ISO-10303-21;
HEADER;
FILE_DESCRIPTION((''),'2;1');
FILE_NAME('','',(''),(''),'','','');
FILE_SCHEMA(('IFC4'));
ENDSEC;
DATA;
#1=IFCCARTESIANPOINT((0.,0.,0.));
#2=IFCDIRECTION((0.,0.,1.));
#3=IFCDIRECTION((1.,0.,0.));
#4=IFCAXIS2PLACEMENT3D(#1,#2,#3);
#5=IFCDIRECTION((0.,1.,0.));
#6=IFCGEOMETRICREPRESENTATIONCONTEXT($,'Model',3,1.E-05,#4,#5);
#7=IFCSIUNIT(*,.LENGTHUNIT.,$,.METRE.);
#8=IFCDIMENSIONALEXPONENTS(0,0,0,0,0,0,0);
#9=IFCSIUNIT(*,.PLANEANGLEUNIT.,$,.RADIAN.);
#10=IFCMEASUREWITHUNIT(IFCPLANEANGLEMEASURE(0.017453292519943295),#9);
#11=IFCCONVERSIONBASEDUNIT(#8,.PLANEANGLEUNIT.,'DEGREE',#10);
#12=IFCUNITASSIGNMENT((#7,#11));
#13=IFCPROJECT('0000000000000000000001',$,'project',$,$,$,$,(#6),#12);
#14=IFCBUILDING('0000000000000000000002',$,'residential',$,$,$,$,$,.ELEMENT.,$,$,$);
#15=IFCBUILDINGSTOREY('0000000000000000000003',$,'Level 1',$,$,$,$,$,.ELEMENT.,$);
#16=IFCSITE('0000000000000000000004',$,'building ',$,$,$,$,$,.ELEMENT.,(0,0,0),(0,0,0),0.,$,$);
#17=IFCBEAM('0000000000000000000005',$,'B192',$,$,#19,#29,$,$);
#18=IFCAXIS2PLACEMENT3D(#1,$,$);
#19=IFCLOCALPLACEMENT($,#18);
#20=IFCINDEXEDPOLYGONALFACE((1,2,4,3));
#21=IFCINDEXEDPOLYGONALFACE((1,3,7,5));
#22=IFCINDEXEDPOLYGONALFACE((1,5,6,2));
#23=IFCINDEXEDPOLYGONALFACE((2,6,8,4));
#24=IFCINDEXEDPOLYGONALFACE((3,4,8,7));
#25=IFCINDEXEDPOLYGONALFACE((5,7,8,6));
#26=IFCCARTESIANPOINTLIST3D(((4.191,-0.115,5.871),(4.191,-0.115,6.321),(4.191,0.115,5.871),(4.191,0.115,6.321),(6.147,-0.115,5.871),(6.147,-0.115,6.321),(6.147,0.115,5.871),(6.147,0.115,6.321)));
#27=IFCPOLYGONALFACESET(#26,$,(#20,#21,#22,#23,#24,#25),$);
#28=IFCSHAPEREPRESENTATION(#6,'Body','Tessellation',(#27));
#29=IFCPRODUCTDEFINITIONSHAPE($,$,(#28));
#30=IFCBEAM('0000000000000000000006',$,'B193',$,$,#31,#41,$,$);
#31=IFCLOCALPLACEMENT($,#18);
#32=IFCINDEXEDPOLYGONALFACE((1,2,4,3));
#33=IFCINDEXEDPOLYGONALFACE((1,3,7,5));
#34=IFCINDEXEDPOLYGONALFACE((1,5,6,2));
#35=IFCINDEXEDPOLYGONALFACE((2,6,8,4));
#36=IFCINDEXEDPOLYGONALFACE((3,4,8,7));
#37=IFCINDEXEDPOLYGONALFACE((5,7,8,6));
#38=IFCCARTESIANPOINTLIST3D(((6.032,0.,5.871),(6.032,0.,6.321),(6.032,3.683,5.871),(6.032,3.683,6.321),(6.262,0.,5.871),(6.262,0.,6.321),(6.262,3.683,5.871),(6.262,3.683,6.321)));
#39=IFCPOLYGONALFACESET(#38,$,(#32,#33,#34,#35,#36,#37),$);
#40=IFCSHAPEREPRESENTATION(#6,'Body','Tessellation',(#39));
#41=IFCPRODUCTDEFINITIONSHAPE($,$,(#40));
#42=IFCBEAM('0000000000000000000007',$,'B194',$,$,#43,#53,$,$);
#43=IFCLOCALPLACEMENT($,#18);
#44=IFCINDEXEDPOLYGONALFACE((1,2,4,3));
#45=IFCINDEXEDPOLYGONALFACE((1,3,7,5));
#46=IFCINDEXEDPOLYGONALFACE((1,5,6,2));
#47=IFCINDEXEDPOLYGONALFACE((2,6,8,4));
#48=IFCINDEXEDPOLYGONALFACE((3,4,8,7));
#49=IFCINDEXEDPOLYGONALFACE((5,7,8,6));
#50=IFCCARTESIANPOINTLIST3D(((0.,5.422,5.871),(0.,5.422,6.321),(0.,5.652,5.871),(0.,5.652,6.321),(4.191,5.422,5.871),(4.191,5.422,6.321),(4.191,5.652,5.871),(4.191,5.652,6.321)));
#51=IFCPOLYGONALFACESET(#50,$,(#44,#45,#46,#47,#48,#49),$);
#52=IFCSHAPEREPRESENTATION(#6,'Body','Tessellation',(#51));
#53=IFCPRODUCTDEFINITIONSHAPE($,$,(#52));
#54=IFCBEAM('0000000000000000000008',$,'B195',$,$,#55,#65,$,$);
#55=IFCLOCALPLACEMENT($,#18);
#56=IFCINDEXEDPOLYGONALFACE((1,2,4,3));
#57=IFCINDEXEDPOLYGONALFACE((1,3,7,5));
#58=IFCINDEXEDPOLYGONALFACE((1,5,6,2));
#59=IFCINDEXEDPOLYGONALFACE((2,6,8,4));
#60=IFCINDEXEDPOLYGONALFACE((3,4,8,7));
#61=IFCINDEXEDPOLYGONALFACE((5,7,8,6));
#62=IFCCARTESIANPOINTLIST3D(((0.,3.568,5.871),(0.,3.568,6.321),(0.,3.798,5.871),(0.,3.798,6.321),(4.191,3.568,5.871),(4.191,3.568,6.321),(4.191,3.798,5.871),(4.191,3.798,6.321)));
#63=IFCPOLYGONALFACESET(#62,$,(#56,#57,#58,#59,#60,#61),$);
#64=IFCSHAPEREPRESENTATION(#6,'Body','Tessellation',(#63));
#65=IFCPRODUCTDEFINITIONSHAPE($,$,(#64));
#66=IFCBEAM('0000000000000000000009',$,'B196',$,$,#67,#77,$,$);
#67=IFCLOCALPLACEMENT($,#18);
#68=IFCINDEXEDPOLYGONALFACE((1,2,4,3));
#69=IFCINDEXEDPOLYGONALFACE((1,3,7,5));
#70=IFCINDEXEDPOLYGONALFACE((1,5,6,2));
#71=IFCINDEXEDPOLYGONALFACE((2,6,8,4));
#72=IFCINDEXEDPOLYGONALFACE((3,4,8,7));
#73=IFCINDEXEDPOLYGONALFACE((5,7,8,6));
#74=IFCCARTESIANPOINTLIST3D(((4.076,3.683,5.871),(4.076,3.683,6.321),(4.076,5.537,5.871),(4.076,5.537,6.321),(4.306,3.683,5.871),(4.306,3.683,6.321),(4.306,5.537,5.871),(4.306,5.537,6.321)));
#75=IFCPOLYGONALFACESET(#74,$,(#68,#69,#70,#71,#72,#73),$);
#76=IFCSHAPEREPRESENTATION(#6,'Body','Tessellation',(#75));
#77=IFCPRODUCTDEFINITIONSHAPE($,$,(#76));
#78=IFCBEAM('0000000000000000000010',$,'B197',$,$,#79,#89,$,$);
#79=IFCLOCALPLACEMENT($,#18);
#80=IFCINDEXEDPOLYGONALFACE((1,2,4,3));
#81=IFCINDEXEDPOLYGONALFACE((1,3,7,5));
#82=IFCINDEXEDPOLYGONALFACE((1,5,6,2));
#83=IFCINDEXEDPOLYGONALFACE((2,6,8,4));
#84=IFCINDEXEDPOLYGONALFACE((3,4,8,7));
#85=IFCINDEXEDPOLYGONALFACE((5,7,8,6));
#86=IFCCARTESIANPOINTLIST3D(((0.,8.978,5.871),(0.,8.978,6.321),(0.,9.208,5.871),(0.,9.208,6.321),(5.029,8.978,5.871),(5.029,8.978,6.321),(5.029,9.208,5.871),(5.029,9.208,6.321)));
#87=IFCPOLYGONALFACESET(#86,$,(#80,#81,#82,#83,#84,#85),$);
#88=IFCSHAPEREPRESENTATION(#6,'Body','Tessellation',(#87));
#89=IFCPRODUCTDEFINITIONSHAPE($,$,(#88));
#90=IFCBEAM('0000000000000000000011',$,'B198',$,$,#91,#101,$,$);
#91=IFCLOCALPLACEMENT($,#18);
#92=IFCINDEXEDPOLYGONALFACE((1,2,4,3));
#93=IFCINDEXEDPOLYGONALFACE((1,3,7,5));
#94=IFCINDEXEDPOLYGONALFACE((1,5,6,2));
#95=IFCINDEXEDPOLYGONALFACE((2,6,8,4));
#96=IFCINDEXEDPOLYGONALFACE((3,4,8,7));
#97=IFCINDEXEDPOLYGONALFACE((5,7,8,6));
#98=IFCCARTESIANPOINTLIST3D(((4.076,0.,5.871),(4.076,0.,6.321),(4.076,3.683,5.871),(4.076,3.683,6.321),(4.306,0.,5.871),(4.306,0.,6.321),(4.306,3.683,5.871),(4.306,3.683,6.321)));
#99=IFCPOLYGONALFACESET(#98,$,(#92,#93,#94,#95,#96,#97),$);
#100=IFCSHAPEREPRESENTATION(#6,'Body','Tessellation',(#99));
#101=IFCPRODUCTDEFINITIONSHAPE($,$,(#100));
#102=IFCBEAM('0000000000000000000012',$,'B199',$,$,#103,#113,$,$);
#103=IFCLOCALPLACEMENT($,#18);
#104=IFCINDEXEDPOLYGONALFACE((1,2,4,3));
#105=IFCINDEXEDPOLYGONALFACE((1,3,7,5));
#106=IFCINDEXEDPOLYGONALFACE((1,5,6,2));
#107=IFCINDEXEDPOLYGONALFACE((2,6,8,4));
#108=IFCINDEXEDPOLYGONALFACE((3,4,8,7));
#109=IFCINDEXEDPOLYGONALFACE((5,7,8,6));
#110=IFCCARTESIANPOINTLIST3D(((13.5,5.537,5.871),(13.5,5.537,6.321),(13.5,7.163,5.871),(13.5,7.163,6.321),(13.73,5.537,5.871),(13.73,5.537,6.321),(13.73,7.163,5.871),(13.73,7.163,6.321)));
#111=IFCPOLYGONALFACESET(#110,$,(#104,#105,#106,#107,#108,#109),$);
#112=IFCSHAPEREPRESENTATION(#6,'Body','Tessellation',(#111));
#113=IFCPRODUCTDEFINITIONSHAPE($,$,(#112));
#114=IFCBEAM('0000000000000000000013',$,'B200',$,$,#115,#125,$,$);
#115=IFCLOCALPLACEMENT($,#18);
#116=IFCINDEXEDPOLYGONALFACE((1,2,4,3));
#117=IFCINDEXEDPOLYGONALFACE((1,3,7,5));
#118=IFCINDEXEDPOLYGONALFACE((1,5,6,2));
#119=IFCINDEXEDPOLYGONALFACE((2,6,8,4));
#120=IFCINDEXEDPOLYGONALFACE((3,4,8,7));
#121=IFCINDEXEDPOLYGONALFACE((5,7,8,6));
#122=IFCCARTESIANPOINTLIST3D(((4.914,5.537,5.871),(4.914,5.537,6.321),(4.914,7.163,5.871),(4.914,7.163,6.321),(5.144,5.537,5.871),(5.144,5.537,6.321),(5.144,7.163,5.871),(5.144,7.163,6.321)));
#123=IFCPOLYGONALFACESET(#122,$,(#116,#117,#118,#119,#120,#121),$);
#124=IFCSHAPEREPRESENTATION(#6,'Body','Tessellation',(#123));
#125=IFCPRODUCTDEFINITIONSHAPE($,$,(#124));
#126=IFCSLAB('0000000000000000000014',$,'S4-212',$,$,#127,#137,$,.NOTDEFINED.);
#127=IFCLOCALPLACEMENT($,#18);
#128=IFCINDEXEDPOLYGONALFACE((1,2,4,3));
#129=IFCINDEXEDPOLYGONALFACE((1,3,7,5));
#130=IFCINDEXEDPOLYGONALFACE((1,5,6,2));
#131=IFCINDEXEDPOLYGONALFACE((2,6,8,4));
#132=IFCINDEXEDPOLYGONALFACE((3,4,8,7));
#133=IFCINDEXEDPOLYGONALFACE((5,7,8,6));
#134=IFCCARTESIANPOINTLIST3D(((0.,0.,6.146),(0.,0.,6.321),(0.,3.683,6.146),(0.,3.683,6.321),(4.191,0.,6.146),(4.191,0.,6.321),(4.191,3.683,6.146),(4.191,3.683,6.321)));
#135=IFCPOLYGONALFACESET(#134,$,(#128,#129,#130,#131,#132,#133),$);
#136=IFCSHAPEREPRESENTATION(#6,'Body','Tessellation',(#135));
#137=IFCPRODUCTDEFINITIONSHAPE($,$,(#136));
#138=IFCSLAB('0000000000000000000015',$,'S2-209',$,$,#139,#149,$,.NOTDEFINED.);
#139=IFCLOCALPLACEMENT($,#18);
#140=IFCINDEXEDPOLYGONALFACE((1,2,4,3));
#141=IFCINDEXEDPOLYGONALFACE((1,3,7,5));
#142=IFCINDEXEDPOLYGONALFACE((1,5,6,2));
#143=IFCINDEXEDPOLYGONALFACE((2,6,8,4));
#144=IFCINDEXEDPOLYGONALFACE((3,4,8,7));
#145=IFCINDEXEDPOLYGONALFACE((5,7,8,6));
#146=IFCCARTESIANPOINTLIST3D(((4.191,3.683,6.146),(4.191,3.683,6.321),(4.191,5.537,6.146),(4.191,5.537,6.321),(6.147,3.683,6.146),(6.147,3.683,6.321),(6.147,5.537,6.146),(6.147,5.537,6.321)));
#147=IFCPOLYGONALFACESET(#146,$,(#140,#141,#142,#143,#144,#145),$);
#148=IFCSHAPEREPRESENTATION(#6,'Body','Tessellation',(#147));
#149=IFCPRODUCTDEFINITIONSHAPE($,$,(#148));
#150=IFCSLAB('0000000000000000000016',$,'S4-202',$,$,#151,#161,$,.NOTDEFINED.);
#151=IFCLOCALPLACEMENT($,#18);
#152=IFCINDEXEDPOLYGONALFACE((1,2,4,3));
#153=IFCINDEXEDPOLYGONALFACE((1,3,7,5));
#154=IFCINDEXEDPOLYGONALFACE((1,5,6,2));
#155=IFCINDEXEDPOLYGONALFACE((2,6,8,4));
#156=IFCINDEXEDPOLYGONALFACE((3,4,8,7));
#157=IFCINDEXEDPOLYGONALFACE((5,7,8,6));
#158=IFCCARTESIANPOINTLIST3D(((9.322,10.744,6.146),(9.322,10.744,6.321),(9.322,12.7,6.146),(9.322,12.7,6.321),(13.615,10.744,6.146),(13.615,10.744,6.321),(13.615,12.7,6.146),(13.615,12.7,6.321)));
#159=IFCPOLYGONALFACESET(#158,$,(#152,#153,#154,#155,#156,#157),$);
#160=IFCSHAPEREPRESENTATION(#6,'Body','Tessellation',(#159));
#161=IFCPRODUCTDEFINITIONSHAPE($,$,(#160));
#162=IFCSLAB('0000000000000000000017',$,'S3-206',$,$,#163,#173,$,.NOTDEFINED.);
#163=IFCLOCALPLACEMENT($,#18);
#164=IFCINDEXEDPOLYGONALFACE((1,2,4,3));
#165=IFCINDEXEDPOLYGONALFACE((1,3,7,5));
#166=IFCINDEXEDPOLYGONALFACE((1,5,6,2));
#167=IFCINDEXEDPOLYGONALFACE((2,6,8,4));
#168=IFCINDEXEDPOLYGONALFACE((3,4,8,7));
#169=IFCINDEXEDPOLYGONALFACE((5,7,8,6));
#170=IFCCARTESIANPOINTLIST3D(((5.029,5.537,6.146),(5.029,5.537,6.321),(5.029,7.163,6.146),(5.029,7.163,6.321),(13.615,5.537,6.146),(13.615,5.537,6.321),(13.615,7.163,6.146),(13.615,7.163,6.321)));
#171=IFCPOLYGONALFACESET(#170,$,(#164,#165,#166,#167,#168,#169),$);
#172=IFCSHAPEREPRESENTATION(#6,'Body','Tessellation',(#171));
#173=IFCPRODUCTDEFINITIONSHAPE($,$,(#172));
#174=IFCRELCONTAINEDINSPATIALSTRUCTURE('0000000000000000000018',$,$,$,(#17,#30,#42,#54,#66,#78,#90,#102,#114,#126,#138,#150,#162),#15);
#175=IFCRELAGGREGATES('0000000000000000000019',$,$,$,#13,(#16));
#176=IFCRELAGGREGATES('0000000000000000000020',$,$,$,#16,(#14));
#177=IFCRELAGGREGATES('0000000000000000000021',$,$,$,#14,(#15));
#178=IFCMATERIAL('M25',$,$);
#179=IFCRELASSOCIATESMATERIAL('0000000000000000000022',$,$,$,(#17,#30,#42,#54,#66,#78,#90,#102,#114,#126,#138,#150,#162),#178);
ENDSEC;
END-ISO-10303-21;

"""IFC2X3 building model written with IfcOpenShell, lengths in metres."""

from ifc_helpers import new_model, entity, si_unit, converted_unit, direction, frame, frame_2d, origin_with_axes, place, context, project, spatial, rectangle, extrude, material, element, save


model = new_model("IFC2X3")

# Units and contexts
model_context = context("Model", 3, precision=1e-05, world=origin_with_axes(), true_north=direction((0.0, 1.0, 0.0)))
ifc_project = project(units=[si_unit("LENGTHUNIT", "METRE"), converted_unit("PLANEANGLEUNIT", "DEGREE", entity("IfcPlaneAngleMeasure", 0.017453292519943295), si_unit("PLANEANGLEUNIT", "RADIAN"), dimensions=[0, 0, 0, 0, 0, 0, 0])], contexts=[model_context])

# Site, building, storey
site = spatial("IfcSite", under=ifc_project, Name="building ", CompositionType="ELEMENT", RefLatitude=(0, 0, 0), RefLongitude=(0, 0, 0), RefElevation=0.0)
building = spatial("IfcBuilding", under=site, Name="residential", CompositionType="ELEMENT")
storey = spatial("IfcBuildingStorey", under=building, Name="Level 1", CompositionType="ELEMENT")

# Beams
ifc_material = material(Name="M25")
placement = place(None, origin_with_axes())
element("IfcBeam", 1, at=placement, inside=storey, material=ifc_material, Name="B192", context=model_context, shape_type="SweptSolid", body=[
    extrude(rectangle(XDim=0.23, YDim=0.45, at=frame_2d((0.0, 0.0), x_axis=(0.0, 1.0, 0.0))), frame((4.191, 0.0, 6.096), z_axis=(1.0, 0.0, 0.0), x_axis=(0.0, 0.0, -1.0)), (0.0, 0.0, 1.0), 1.956),
])
element("IfcBeam", 2, at=placement, inside=storey, material=ifc_material, Name="B193", context=model_context, shape_type="SweptSolid", body=[
    extrude(rectangle(XDim=0.23, YDim=0.45, at=frame_2d((0.0, 0.0), x_axis=(0.0, 1.0, 0.0))), frame((6.147, 0.0, 6.096), z_axis=(0.0, 1.0, 0.0), x_axis=(0.0, 0.0, -1.0)), (0.0, 0.0, 1.0), 3.683),
])
element("IfcBeam", 3, at=placement, inside=storey, material=ifc_material, Name="B194", context=model_context, shape_type="SweptSolid", body=[
    extrude(rectangle(XDim=0.23, YDim=0.45, at=frame_2d((0.0, 0.0), x_axis=(0.0, 1.0, 0.0))), frame((0.0, 5.537, 6.096), z_axis=(1.0, 0.0, 0.0), x_axis=(0.0, 0.0, -1.0)), (0.0, 0.0, 1.0), 4.191),
])
element("IfcBeam", 4, at=placement, inside=storey, material=ifc_material, Name="B195", context=model_context, shape_type="SweptSolid", body=[
    extrude(rectangle(XDim=0.23, YDim=0.45, at=frame_2d((0.0, 0.0), x_axis=(0.0, 1.0, 0.0))), frame((0.0, 3.683, 6.096), z_axis=(1.0, 0.0, 0.0), x_axis=(0.0, 0.0, -1.0)), (0.0, 0.0, 1.0), 4.191),
])
element("IfcBeam", 5, at=placement, inside=storey, material=ifc_material, Name="B196", context=model_context, shape_type="SweptSolid", body=[
    extrude(rectangle(XDim=0.23, YDim=0.45, at=frame_2d((0.0, 0.0), x_axis=(0.0, 1.0, 0.0))), frame((4.191, 3.683, 6.096), z_axis=(0.0, 1.0, 0.0), x_axis=(0.0, 0.0, -1.0)), (0.0, 0.0, 1.0), 1.854),
])
element("IfcBeam", 6, at=placement, inside=storey, material=ifc_material, Name="B197", context=model_context, shape_type="SweptSolid", body=[
    extrude(rectangle(XDim=0.23, YDim=0.45, at=frame_2d((0.0, 0.0), x_axis=(0.0, 1.0, 0.0))), frame((0.0, 9.093, 6.096), z_axis=(1.0, 0.0, 0.0), x_axis=(0.0, 0.0, -1.0)), (0.0, 0.0, 1.0), 5.029),
])
element("IfcBeam", 7, at=placement, inside=storey, material=ifc_material, Name="B198", context=model_context, shape_type="SweptSolid", body=[
    extrude(rectangle(XDim=0.23, YDim=0.45, at=frame_2d((0.0, 0.0), x_axis=(0.0, 1.0, 0.0))), frame((4.191, 0.0, 6.096), z_axis=(0.0, 1.0, 0.0), x_axis=(0.0, 0.0, -1.0)), (0.0, 0.0, 1.0), 3.683),
])
element("IfcBeam", 8, at=placement, inside=storey, material=ifc_material, Name="B199", context=model_context, shape_type="SweptSolid", body=[
    extrude(rectangle(XDim=0.23, YDim=0.45, at=frame_2d((0.0, 0.0), x_axis=(0.0, 1.0, 0.0))), frame((13.615, 5.537, 6.096), z_axis=(0.0, 1.0, 0.0), x_axis=(0.0, 0.0, -1.0)), (0.0, 0.0, 1.0), 1.626),
])
element("IfcBeam", 9, at=placement, inside=storey, material=ifc_material, Name="B200", context=model_context, shape_type="SweptSolid", body=[
    extrude(rectangle(XDim=0.23, YDim=0.45, at=frame_2d((0.0, 0.0), x_axis=(0.0, 1.0, 0.0))), frame((5.029, 5.537, 6.096), z_axis=(0.0, 1.0, 0.0), x_axis=(0.0, 0.0, -1.0)), (0.0, 0.0, 1.0), 1.626),
])

# Slabs
element("IfcSlab", 10, at=placement, inside=storey, material=ifc_material, Name="S4-212", PredefinedType="NOTDEFINED", context=model_context, shape_type="SweptSolid", body=[
    extrude(rectangle(XDim=4.191, YDim=3.683, at=frame_2d((0.0, 0.0), x_axis=(1.0, 0.0, 0.0))), frame((2.0955, 1.8415, 6.146), z_axis=(0.0, 0.0, 1.0), x_axis=(1.0, 0.0, 0.0)), (0.0, 0.0, 1.0), 0.175),
])
element("IfcSlab", 11, at=placement, inside=storey, material=ifc_material, Name="S2-209", PredefinedType="NOTDEFINED", context=model_context, shape_type="SweptSolid", body=[
    extrude(rectangle(XDim=1.956, YDim=1.854, at=frame_2d((0.0, 0.0), x_axis=(1.0, 0.0, 0.0))), frame((5.169, 4.61, 6.146), z_axis=(0.0, 0.0, 1.0), x_axis=(1.0, 0.0, 0.0)), (0.0, 0.0, 1.0), 0.175),
])
element("IfcSlab", 12, at=placement, inside=storey, material=ifc_material, Name="S4-202", PredefinedType="NOTDEFINED", context=model_context, shape_type="SweptSolid", body=[
    extrude(rectangle(XDim=4.293, YDim=1.956, at=frame_2d((0.0, 0.0), x_axis=(1.0, 0.0, 0.0))), frame((11.4685, 11.722, 6.146), z_axis=(0.0, 0.0, 1.0), x_axis=(1.0, 0.0, 0.0)), (0.0, 0.0, 1.0), 0.175),
])
element("IfcSlab", 13, at=placement, inside=storey, material=ifc_material, Name="S3-206", PredefinedType="NOTDEFINED", context=model_context, shape_type="SweptSolid", body=[
    extrude(rectangle(XDim=8.586, YDim=1.626, at=frame_2d((0.0, 0.0), x_axis=(1.0, 0.0, 0.0))), frame((9.322, 6.35, 6.146), z_axis=(0.0, 0.0, 1.0), x_axis=(1.0, 0.0, 0.0)), (0.0, 0.0, 1.0), 0.175),
])

save(model, "model.ifc")
